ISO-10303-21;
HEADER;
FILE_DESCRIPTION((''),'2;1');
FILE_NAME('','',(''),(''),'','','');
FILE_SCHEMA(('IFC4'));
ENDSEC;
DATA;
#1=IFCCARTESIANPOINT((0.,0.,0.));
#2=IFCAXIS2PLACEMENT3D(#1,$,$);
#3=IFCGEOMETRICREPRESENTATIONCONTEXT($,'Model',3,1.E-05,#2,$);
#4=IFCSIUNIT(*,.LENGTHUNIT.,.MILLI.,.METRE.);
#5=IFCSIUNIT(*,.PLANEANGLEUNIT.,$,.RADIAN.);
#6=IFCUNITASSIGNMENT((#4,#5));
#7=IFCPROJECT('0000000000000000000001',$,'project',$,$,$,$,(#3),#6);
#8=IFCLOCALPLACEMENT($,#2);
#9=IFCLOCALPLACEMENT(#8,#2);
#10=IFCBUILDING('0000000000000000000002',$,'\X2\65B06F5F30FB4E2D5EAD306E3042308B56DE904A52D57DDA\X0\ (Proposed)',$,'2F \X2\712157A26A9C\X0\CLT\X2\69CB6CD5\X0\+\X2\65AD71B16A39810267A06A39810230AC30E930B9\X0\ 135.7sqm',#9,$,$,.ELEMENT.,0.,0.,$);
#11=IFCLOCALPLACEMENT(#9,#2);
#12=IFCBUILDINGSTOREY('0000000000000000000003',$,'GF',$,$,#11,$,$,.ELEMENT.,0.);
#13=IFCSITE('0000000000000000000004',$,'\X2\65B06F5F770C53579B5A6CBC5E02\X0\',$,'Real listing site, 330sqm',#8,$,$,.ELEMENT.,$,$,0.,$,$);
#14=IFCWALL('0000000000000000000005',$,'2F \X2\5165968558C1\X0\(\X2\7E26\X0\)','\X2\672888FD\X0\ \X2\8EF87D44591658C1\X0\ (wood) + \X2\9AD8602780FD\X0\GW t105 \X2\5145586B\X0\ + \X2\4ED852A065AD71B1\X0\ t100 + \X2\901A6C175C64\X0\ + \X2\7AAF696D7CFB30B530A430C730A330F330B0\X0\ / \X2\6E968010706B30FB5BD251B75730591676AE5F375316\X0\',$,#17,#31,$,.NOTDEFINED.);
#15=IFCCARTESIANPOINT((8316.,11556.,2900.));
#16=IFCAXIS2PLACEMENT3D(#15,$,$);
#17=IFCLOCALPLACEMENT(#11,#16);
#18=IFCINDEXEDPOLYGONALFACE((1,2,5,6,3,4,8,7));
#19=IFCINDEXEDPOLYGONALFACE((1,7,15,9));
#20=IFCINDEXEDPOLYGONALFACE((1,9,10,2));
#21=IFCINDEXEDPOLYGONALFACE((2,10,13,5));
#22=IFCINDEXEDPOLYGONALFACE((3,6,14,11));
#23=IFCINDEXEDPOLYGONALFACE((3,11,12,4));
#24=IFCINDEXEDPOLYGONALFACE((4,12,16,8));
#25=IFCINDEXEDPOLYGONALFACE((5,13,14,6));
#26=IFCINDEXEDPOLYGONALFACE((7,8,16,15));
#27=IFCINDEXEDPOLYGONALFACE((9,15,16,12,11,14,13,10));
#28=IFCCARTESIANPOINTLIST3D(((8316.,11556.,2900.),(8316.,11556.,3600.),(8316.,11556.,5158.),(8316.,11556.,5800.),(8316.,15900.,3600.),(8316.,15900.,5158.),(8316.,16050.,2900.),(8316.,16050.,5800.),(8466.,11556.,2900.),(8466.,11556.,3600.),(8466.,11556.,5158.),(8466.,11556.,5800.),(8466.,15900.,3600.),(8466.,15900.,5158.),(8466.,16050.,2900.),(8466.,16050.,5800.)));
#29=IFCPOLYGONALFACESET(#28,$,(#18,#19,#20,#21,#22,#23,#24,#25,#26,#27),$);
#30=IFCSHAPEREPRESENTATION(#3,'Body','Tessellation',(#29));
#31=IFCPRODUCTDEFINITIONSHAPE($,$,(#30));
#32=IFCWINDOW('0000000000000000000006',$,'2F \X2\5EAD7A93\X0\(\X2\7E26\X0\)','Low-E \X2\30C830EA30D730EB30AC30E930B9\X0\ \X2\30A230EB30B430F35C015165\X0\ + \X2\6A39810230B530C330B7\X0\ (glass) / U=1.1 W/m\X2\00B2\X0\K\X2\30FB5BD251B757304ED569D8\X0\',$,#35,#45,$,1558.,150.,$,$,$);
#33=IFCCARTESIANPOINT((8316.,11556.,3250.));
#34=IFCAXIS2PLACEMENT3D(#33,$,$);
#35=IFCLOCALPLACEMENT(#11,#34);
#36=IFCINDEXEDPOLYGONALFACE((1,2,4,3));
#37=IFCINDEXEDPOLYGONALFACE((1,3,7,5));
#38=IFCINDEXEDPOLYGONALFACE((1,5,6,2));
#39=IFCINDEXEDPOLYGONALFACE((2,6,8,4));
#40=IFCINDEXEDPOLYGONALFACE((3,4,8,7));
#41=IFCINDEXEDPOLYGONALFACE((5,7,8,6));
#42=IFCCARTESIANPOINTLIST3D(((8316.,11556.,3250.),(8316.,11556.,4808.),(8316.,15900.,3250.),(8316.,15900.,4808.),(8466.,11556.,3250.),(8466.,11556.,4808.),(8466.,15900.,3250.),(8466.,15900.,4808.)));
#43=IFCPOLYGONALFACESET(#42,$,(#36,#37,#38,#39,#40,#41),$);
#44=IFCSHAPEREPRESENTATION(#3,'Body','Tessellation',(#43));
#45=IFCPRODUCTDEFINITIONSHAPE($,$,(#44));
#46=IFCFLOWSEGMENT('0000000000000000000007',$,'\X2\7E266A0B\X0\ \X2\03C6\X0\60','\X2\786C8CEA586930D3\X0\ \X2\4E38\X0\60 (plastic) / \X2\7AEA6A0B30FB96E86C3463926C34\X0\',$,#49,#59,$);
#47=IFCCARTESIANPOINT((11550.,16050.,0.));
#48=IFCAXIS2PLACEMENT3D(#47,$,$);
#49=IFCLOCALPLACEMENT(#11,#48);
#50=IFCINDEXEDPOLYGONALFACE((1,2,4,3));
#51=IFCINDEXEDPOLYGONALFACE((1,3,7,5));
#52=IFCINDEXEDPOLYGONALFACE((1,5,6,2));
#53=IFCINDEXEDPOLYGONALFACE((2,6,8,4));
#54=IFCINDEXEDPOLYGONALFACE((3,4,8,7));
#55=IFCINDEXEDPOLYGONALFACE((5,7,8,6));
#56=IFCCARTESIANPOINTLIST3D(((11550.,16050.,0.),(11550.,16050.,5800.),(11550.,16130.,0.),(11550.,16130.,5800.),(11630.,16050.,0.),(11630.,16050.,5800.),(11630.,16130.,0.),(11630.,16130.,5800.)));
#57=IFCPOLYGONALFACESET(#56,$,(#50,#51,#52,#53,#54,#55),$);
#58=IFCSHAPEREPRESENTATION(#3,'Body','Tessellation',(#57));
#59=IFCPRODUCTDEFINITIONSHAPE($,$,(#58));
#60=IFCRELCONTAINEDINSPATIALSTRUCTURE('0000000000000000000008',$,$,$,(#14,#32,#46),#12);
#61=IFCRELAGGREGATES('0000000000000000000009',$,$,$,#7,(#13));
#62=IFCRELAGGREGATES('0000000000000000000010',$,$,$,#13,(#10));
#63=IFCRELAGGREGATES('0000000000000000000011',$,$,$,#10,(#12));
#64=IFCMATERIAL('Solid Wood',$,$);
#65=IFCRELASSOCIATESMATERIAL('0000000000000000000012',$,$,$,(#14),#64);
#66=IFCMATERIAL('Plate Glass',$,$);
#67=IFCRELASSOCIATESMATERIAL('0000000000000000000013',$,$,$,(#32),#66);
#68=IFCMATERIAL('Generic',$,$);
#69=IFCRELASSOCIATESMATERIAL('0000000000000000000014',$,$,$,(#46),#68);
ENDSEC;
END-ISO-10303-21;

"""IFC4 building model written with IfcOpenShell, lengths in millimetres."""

from ifc_helpers import new_model, si_unit, frame, frame_2d, origin, place, context, project, spatial, rectangle, extrude, material, element, fill, save


model = new_model("IFC4")

# Units and contexts
model_context = context("Model", 3, precision=1e-05, world=origin())
ifc_project = project(units=[si_unit("LENGTHUNIT", "METRE", prefix="MILLI"), si_unit("PLANEANGLEUNIT", "RADIAN")], contexts=[model_context])

# Site, building, storey
site_placement = place(None, origin())
site = spatial("IfcSite", under=ifc_project, at=site_placement, Name="新潟県南魚沼市", ObjectType="Real listing site, 330sqm", CompositionType="ELEMENT", RefElevation=0.0)
building_placement = place(site_placement, origin())
building = spatial("IfcBuilding", under=site, at=building_placement, Name="新潟・中庭のある回遊動線 (Proposed)", ObjectType="2F 無垢檜CLT構法+断熱樹脂枠樹脂ガラス 135.7sqm", CompositionType="ELEMENT", ElevationOfRefHeight=0.0, ElevationOfTerrain=0.0)
storey_placement = place(building_placement, origin())
storey = spatial("IfcBuildingStorey", under=building, at=storey_placement, Name="GF", CompositionType="ELEMENT", Elevation=0.0)

# Shared definitions
ifc_material_1 = material(Name="Solid Wood")

# Shared definitions
ifc_material_2 = material(Name="Plate Glass")

# Wall, opening, window
wall_1_placement = place(storey_placement, frame((8316.0, 11556.0, 2900.0)))
wall_1 = element("IfcWall", 1, at=wall_1_placement, inside=storey, material=ifc_material_1, Name="2F 入隅壁(縦)", Description="木製 軸組外壁 (wood) + 高性能GW t105 充填 + 付加断熱 t100 + 通気層 + 窯業系サイディング / 準耐火・寒冷地外皮強化", PredefinedType="NOTDEFINED", context=model_context, shape_type="SweptSolid", body=[
    extrude(rectangle(XDim=150.0, YDim=4494.0, at=frame_2d((75.0, 2247.0))), frame((8316.0, 11556.0, 2900.0)), (0.0, 0.0, 1.0), 2900.0),
])
opening_1_placement = place(storey_placement, frame((8316.0, 11556.0, 3250.0)))
opening_1 = element("IfcOpeningElement", 2, at=opening_1_placement, cuts=wall_1, PredefinedType="NOTDEFINED", context=model_context, shape_type="SweptSolid", body=[
    extrude(rectangle(XDim=150.0, YDim=4344.0, at=frame_2d((75.0, 2172.0))), frame((8316.0, 11556.0, 3250.0)), (0.0, 0.0, 1.0), 1558.0),
])
window_1_placement = place(storey_placement, frame((8316.0, 11556.0, 3250.0)))
window_1 = element("IfcWindow", 3, at=window_1_placement, inside=storey, material=ifc_material_2, Name="2F 庭窓(縦)", Description="Low-E トリプルガラス アルゴン封入 + 樹脂サッシ (glass) / U=1.1 W/m²K・寒冷地仕様", OverallHeight=1558.0, OverallWidth=150.0, context=model_context, shape_type="SweptSolid", body=[
    extrude(rectangle(XDim=150.0, YDim=4344.0, at=frame_2d((75.0, 2172.0))), frame((8316.0, 11556.0, 3250.0)), (0.0, 0.0, 1.0), 1558.0),
])
fill(opening_1, window_1)

# Flow segment
ifc_material_3 = material(Name="Generic")
flow_segment_placement = place(storey_placement, frame((11550.0, 16050.0, 0.0)))
element("IfcFlowSegment", 4, at=flow_segment_placement, inside=storey, material=ifc_material_3, Name="縦樋 φ60", Description="硬質塩ビ 丸60 (plastic) / 竪樋・雨水排水", context=model_context, shape_type="SweptSolid", body=[
    extrude(rectangle(XDim=80.0, YDim=80.0, at=frame_2d((40.0, 40.0))), frame((11550.0, 16050.0, 0.0)), (0.0, 0.0, 1.0), 5800.0),
])

save(model, "model.ifc")
